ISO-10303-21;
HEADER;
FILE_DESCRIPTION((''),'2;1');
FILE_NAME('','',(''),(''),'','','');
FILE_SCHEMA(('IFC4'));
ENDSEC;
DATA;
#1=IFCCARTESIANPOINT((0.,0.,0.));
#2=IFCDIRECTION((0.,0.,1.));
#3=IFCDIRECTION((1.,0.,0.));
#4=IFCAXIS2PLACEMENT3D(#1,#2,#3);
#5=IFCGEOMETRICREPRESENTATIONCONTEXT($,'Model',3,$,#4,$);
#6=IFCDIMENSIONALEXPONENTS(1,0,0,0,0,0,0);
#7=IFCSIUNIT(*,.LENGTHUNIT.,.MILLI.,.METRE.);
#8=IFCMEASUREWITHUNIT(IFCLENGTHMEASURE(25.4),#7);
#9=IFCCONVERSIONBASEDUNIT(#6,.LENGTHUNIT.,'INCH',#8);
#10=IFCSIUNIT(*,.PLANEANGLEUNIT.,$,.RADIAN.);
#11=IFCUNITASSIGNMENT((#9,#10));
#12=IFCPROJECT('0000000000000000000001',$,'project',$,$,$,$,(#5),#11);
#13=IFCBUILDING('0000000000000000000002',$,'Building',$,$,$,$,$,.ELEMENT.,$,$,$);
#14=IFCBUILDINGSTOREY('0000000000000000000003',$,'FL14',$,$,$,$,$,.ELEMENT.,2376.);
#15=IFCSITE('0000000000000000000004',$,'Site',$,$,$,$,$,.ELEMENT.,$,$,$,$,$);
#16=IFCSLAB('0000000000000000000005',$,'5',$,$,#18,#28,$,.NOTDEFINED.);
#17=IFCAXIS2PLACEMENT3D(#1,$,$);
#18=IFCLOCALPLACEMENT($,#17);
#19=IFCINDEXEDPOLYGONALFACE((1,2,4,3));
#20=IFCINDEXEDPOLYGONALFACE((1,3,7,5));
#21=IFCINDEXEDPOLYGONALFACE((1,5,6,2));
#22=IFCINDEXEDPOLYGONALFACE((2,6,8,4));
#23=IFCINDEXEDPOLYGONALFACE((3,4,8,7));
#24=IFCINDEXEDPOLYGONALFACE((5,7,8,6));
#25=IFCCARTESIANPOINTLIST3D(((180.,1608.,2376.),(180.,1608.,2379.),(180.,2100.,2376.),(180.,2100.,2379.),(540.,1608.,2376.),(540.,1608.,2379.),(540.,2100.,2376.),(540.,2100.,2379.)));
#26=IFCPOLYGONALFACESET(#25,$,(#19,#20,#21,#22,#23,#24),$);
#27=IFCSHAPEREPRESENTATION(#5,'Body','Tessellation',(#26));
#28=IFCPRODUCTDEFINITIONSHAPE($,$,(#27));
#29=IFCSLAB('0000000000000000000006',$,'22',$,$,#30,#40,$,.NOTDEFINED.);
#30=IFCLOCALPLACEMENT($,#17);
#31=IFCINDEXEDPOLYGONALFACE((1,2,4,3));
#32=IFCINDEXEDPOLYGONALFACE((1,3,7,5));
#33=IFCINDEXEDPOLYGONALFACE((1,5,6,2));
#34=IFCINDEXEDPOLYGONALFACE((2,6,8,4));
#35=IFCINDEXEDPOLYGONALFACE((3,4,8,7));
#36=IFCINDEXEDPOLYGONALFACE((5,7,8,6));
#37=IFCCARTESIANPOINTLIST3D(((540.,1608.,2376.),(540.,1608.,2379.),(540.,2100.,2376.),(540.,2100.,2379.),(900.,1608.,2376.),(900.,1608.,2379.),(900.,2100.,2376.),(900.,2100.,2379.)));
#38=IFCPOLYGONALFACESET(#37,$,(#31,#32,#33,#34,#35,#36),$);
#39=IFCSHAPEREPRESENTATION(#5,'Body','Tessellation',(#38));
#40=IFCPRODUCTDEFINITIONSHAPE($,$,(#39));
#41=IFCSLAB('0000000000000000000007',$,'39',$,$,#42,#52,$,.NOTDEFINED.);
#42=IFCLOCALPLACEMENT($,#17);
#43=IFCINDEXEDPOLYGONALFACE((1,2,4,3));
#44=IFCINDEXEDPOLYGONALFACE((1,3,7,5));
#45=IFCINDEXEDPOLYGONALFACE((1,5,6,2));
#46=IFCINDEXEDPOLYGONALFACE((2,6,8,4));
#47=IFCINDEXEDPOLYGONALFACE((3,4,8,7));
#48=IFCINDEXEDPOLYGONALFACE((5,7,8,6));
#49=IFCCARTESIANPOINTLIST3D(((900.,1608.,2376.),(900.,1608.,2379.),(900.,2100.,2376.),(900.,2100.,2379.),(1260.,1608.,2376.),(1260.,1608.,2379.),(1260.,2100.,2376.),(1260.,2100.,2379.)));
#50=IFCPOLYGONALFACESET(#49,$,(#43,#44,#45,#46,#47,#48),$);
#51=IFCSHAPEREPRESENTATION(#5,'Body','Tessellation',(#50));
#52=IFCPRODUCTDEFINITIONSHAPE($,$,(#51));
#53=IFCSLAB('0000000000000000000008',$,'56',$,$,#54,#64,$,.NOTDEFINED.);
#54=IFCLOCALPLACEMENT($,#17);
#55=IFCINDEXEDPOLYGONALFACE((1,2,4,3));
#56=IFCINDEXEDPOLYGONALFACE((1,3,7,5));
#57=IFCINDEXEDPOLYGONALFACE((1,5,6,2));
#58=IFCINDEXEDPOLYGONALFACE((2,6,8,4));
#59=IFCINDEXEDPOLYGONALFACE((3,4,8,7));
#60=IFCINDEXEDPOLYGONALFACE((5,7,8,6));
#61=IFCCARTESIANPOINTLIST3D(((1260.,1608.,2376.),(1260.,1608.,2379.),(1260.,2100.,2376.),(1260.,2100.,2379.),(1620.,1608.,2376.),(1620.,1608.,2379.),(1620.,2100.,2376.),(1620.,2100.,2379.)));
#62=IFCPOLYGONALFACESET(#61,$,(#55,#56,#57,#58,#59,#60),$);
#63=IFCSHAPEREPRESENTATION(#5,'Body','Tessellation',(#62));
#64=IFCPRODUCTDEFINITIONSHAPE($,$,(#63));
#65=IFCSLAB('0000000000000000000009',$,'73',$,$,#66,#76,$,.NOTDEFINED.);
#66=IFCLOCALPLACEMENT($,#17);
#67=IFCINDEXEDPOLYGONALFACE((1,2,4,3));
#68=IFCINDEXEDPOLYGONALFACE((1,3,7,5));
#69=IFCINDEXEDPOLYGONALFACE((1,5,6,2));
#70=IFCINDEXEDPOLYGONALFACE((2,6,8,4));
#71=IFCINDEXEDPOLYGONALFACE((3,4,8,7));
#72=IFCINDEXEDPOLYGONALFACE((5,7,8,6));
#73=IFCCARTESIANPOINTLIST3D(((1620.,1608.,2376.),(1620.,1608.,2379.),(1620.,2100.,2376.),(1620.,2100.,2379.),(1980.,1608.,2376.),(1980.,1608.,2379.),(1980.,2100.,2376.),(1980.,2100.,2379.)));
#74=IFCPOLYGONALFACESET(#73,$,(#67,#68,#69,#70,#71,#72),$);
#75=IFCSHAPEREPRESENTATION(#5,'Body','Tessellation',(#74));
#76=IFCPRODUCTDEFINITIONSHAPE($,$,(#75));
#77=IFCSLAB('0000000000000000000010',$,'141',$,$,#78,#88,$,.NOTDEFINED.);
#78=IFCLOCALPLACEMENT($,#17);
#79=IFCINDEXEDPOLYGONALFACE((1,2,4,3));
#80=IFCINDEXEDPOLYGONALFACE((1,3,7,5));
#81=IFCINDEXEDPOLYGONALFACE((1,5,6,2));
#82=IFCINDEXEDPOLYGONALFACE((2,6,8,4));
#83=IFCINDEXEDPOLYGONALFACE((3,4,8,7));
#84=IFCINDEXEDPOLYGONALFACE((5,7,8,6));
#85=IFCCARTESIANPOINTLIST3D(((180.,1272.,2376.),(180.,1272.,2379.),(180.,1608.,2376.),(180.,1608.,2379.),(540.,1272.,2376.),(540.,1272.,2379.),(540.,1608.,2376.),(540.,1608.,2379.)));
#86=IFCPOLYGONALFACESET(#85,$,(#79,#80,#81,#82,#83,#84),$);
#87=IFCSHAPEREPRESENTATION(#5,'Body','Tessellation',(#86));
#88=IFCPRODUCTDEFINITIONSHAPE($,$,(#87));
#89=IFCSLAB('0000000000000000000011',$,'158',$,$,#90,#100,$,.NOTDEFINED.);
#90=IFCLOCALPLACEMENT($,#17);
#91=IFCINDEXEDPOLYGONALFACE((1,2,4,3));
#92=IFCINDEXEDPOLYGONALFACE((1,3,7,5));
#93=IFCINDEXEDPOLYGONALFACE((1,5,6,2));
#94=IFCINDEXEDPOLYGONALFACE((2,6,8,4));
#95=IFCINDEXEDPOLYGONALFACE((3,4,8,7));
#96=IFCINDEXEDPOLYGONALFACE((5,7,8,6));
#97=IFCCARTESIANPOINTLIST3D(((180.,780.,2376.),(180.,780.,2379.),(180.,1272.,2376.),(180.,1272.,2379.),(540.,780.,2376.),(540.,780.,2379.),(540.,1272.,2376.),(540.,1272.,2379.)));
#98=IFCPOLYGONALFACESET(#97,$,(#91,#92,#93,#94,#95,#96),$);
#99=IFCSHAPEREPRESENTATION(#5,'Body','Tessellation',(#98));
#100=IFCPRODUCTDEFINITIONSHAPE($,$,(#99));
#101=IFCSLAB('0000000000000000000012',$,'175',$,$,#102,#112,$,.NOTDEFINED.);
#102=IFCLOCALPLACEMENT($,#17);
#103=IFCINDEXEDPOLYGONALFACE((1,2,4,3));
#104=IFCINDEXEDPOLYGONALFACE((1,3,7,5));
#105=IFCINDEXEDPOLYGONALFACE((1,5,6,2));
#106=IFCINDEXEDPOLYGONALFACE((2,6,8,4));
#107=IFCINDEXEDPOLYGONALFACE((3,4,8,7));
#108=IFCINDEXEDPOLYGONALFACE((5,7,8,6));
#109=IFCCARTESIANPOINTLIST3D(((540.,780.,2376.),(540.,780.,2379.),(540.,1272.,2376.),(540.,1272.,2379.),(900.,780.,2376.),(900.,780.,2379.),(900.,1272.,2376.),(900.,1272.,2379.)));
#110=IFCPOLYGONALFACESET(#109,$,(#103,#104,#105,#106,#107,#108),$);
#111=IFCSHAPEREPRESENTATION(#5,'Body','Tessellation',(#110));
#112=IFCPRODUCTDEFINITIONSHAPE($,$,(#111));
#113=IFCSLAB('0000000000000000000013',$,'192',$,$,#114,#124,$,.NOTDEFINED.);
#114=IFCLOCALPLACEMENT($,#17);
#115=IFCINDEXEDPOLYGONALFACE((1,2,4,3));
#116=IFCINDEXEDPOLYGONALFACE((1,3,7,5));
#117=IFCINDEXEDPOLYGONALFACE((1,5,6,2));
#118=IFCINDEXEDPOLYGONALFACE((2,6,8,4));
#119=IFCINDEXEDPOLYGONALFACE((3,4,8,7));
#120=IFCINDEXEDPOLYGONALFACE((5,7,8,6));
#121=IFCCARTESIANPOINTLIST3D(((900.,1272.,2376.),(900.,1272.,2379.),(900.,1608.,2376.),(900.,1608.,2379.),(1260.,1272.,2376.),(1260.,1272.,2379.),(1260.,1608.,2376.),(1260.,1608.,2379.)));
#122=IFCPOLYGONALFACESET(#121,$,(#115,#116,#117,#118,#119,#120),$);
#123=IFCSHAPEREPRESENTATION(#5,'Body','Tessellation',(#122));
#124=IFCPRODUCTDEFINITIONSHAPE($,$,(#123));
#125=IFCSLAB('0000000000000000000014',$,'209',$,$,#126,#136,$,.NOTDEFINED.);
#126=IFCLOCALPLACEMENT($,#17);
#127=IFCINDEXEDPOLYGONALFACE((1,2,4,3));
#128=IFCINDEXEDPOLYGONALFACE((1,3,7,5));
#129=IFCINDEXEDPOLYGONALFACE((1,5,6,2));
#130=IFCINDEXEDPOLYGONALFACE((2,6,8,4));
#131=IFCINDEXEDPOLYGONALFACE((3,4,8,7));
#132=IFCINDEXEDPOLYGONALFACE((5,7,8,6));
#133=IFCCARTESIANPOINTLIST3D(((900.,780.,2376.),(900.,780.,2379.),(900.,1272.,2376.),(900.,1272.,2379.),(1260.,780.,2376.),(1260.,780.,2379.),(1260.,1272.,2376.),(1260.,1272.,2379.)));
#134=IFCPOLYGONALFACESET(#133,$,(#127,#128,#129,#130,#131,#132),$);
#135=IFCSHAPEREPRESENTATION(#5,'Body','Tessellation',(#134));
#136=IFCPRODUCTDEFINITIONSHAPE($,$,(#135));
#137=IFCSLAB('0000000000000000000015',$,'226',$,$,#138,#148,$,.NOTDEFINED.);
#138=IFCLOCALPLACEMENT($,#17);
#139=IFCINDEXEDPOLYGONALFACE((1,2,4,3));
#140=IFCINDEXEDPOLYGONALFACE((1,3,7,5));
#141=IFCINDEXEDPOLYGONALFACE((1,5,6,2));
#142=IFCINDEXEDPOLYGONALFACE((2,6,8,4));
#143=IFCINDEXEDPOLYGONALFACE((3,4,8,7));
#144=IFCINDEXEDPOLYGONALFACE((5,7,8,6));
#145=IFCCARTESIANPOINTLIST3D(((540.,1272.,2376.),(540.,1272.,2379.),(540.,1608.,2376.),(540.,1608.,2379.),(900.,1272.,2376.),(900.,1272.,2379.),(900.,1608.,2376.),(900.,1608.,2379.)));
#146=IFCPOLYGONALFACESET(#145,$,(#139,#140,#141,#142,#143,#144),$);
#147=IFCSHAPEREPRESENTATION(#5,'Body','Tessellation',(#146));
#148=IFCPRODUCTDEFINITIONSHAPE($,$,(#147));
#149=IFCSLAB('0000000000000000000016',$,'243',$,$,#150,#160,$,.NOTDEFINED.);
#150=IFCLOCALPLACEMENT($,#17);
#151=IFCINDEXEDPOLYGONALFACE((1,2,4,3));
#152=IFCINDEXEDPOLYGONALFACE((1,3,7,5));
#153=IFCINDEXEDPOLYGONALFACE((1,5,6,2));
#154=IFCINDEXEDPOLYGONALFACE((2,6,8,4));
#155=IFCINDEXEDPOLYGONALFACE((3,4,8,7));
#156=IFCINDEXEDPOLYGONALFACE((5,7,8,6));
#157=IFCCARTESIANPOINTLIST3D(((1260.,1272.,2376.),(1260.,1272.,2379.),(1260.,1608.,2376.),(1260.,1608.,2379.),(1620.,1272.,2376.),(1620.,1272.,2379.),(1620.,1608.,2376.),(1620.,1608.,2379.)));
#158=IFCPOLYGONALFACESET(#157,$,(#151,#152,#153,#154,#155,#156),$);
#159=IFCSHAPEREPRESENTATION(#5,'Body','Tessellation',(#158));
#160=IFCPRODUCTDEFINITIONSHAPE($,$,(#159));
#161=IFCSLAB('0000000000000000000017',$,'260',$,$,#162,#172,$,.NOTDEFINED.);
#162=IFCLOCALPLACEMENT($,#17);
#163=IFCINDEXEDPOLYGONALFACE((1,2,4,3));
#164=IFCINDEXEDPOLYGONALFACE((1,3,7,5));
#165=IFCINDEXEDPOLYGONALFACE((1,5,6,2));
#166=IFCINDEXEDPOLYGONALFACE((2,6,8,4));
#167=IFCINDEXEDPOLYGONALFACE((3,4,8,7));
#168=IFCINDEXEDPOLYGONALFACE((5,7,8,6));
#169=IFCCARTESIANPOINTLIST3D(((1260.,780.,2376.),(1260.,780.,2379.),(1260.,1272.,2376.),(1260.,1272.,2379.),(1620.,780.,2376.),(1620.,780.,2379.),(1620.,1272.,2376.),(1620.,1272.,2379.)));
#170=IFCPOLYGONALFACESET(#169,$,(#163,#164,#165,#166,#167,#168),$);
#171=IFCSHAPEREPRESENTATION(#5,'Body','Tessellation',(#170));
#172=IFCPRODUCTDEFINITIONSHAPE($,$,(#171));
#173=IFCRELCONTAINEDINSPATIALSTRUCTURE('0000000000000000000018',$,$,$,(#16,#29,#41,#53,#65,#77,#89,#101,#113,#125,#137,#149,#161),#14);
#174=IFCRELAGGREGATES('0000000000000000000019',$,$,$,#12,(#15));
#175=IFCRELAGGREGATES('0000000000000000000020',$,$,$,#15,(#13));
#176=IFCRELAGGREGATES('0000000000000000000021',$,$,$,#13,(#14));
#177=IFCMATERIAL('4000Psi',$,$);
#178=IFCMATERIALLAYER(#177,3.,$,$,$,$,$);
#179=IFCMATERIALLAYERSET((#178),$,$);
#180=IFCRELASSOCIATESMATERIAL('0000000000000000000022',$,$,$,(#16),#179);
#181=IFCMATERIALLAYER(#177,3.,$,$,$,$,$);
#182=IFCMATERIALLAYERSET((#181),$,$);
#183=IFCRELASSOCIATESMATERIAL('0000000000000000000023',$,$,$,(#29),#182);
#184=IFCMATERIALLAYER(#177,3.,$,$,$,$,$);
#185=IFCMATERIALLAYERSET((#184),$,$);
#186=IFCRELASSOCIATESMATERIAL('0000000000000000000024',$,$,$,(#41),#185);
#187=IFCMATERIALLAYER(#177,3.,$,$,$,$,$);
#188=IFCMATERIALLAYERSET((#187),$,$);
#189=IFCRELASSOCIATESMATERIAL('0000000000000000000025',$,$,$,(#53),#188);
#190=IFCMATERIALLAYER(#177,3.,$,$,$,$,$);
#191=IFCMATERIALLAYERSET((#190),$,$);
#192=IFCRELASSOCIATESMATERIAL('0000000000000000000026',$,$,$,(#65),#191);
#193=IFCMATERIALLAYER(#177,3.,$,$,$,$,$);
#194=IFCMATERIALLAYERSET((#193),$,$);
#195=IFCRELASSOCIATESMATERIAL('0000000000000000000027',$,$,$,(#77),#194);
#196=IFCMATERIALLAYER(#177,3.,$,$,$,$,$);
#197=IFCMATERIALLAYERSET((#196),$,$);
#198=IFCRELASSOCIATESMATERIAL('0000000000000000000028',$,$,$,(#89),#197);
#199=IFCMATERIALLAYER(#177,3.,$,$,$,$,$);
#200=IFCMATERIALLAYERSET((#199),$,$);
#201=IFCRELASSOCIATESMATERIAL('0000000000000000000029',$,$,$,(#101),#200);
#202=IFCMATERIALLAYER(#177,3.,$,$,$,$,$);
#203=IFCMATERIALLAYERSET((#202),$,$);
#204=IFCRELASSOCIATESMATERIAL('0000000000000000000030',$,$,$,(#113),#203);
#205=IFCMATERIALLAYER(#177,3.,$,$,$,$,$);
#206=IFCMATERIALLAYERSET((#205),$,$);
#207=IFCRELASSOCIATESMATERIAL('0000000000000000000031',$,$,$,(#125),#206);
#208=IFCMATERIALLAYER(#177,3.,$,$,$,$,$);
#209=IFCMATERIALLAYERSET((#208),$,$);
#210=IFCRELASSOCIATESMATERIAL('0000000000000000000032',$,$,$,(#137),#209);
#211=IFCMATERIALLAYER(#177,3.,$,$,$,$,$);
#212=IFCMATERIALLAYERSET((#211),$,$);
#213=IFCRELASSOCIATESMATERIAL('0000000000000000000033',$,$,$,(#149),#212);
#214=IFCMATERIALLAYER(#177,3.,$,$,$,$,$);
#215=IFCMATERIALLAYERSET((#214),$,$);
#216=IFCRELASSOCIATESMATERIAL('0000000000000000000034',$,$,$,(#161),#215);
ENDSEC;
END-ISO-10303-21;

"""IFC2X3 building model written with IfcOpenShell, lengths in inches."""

from ifc_helpers import new_model, entity, si_unit, converted_unit, frame, origin_with_axes, place, context, project, spatial, polyline, outline, extrude, material, layer, layer_set, layer_usage, element, save


model = new_model("IFC2X3")

# Units and contexts
model_context = context("Model", 3, world=origin_with_axes())
ifc_project = project(units=[converted_unit("LENGTHUNIT", "INCH", entity("IfcLengthMeasure", 25.4), si_unit("LENGTHUNIT", "METRE", prefix="MILLI"), dimensions=[1, 0, 0, 0, 0, 0, 0]), si_unit("PLANEANGLEUNIT", "RADIAN")], contexts=[model_context])

# Site, building, storey
site = spatial("IfcSite", under=ifc_project, Name="Site", CompositionType="ELEMENT")
building = spatial("IfcBuilding", under=site, Name="Building", CompositionType="ELEMENT")
storey = spatial("IfcBuildingStorey", under=building, Name="FL14", CompositionType="ELEMENT", Elevation=2376.0)

# Slabs
ifc_material_1 = material(Name="4000Psi")
ifc_layer_1 = layer(ifc_material_1, 3.0)
ifc_layer_set_1 = layer_set([ifc_layer_1])
ifc_layer_usage_1 = layer_usage(ifc_layer_set_1, "AXIS2", "POSITIVE", -3.0)
slab_1_placement = place(None, frame((180.0, 1608.0, 2376.0), z_axis=(0.0, 0.0, 1.0), x_axis=(1.0, 0.0, 0.0)))
element("IfcSlab", 1, at=slab_1_placement, inside=storey, material=ifc_layer_usage_1, Name="5", PredefinedType="NOTDEFINED", context=model_context, shape_type="SweptSolid", body=[
    extrude(outline(polyline([(0.0, 0.0), (360.0, 0.0), (360.0, 492.0), (0.0, 492.0), (0.0, 0.0)])), origin_with_axes(), (0.0, 0.0, 1.0), 3.0),
])
ifc_layer_2 = layer(ifc_material_1, 3.0)
ifc_layer_set_2 = layer_set([ifc_layer_2])
ifc_layer_usage_2 = layer_usage(ifc_layer_set_2, "AXIS2", "POSITIVE", -3.0)
slab_2_placement = place(None, frame((540.0, 1608.0, 2376.0), z_axis=(0.0, 0.0, 1.0), x_axis=(1.0, 0.0, 0.0)))
element("IfcSlab", 2, at=slab_2_placement, inside=storey, material=ifc_layer_usage_2, Name="22", PredefinedType="NOTDEFINED", context=model_context, shape_type="SweptSolid", body=[
    extrude(outline(polyline([(0.0, 0.0), (360.0, 0.0), (360.0, 492.0), (0.0, 492.0), (0.0, 0.0)])), origin_with_axes(), (0.0, 0.0, 1.0), 3.0),
])
ifc_layer_3 = layer(ifc_material_1, 3.0)
ifc_layer_set_3 = layer_set([ifc_layer_3])
ifc_layer_usage_3 = layer_usage(ifc_layer_set_3, "AXIS2", "POSITIVE", -3.0)
slab_3_placement = place(None, frame((900.0, 1608.0, 2376.0), z_axis=(0.0, 0.0, 1.0), x_axis=(1.0, 0.0, 0.0)))
element("IfcSlab", 3, at=slab_3_placement, inside=storey, material=ifc_layer_usage_3, Name="39", PredefinedType="NOTDEFINED", context=model_context, shape_type="SweptSolid", body=[
    extrude(outline(polyline([(0.0, 0.0), (360.0, 0.0), (360.0, 492.0), (0.0, 492.0), (0.0, 0.0)])), origin_with_axes(), (0.0, 0.0, 1.0), 3.0),
])
ifc_layer_4 = layer(ifc_material_1, 3.0)
ifc_layer_set_4 = layer_set([ifc_layer_4])
ifc_layer_usage_4 = layer_usage(ifc_layer_set_4, "AXIS2", "POSITIVE", -3.0)
slab_4_placement = place(None, frame((1260.0, 1608.0, 2376.0), z_axis=(0.0, 0.0, 1.0), x_axis=(1.0, 0.0, 0.0)))
element("IfcSlab", 4, at=slab_4_placement, inside=storey, material=ifc_layer_usage_4, Name="56", PredefinedType="NOTDEFINED", context=model_context, shape_type="SweptSolid", body=[
    extrude(outline(polyline([(0.0, 0.0), (360.0, 0.0), (360.0, 492.0), (0.0, 492.0), (0.0, 0.0)])), origin_with_axes(), (0.0, 0.0, 1.0), 3.0),
])
ifc_layer_5 = layer(ifc_material_1, 3.0)
ifc_layer_set_5 = layer_set([ifc_layer_5])
ifc_layer_usage_5 = layer_usage(ifc_layer_set_5, "AXIS2", "POSITIVE", -3.0)
slab_5_placement = place(None, frame((1620.0, 1608.0, 2376.0), z_axis=(0.0, 0.0, 1.0), x_axis=(1.0, 0.0, 0.0)))
element("IfcSlab", 5, at=slab_5_placement, inside=storey, material=ifc_layer_usage_5, Name="73", PredefinedType="NOTDEFINED", context=model_context, shape_type="SweptSolid", body=[
    extrude(outline(polyline([(0.0, 0.0), (360.0, 0.0), (360.0, 492.0), (0.0, 492.0), (0.0, 0.0)])), origin_with_axes(), (0.0, 0.0, 1.0), 3.0),
])
ifc_layer_6 = layer(ifc_material_1, 3.0)
ifc_layer_set_6 = layer_set([ifc_layer_6])
ifc_layer_usage_6 = layer_usage(ifc_layer_set_6, "AXIS2", "POSITIVE", -3.0)
slab_6_placement = place(None, frame((180.0, 1272.0, 2376.0), z_axis=(0.0, 0.0, 1.0), x_axis=(1.0, 0.0, 0.0)))
element("IfcSlab", 6, at=slab_6_placement, inside=storey, material=ifc_layer_usage_6, Name="141", PredefinedType="NOTDEFINED", context=model_context, shape_type="SweptSolid", body=[
    extrude(outline(polyline([(0.0, 0.0), (360.0, 0.0), (360.0, 336.0), (0.0, 336.0), (0.0, 0.0)])), origin_with_axes(), (0.0, 0.0, 1.0), 3.0),
])
ifc_layer_7 = layer(ifc_material_1, 3.0)
ifc_layer_set_7 = layer_set([ifc_layer_7])
ifc_layer_usage_7 = layer_usage(ifc_layer_set_7, "AXIS2", "POSITIVE", -3.0)
slab_7_placement = place(None, frame((180.0, 780.0, 2376.0), z_axis=(0.0, 0.0, 1.0), x_axis=(1.0, 0.0, 0.0)))
element("IfcSlab", 7, at=slab_7_placement, inside=storey, material=ifc_layer_usage_7, Name="158", PredefinedType="NOTDEFINED", context=model_context, shape_type="SweptSolid", body=[
    extrude(outline(polyline([(0.0, 0.0), (360.0, 0.0), (360.0, 492.0), (0.0, 492.0), (0.0, 0.0)])), origin_with_axes(), (0.0, 0.0, 1.0), 3.0),
])
ifc_layer_8 = layer(ifc_material_1, 3.0)
ifc_layer_set_8 = layer_set([ifc_layer_8])
ifc_layer_usage_8 = layer_usage(ifc_layer_set_8, "AXIS2", "POSITIVE", -3.0)
slab_8_placement = place(None, frame((540.0, 780.0, 2376.0), z_axis=(0.0, 0.0, 1.0), x_axis=(1.0, 0.0, 0.0)))
element("IfcSlab", 8, at=slab_8_placement, inside=storey, material=ifc_layer_usage_8, Name="175", PredefinedType="NOTDEFINED", context=model_context, shape_type="SweptSolid", body=[
    extrude(outline(polyline([(0.0, 0.0), (360.0, 0.0), (360.0, 492.0), (0.0, 492.0), (0.0, 0.0)])), origin_with_axes(), (0.0, 0.0, 1.0), 3.0),
])
ifc_layer_9 = layer(ifc_material_1, 3.0)
ifc_layer_set_9 = layer_set([ifc_layer_9])
ifc_layer_usage_9 = layer_usage(ifc_layer_set_9, "AXIS2", "POSITIVE", -3.0)
slab_9_placement = place(None, frame((900.0, 1272.0, 2376.0), z_axis=(0.0, 0.0, 1.0), x_axis=(1.0, 0.0, 0.0)))
element("IfcSlab", 9, at=slab_9_placement, inside=storey, material=ifc_layer_usage_9, Name="192", PredefinedType="NOTDEFINED", context=model_context, shape_type="SweptSolid", body=[
    extrude(outline(polyline([(0.0, 0.0), (360.0, 0.0), (360.0, 336.0), (0.0, 336.0), (0.0, 0.0)])), origin_with_axes(), (0.0, 0.0, 1.0), 3.0),
])
ifc_layer_10 = layer(ifc_material_1, 3.0)
ifc_layer_set_10 = layer_set([ifc_layer_10])
ifc_layer_usage_10 = layer_usage(ifc_layer_set_10, "AXIS2", "POSITIVE", -3.0)
slab_10_placement = place(None, frame((900.0, 780.0, 2376.0), z_axis=(0.0, 0.0, 1.0), x_axis=(1.0, 0.0, 0.0)))
element("IfcSlab", 10, at=slab_10_placement, inside=storey, material=ifc_layer_usage_10, Name="209", PredefinedType="NOTDEFINED", context=model_context, shape_type="SweptSolid", body=[
    extrude(outline(polyline([(0.0, 0.0), (360.0, 0.0), (360.0, 492.0), (0.0, 492.0), (0.0, 0.0)])), origin_with_axes(), (0.0, 0.0, 1.0), 3.0),
])
ifc_layer_11 = layer(ifc_material_1, 3.0)
ifc_layer_set_11 = layer_set([ifc_layer_11])
ifc_layer_usage_11 = layer_usage(ifc_layer_set_11, "AXIS2", "POSITIVE", -3.0)
slab_11_placement = place(None, frame((540.0, 1272.0, 2376.0), z_axis=(0.0, 0.0, 1.0), x_axis=(1.0, 0.0, 0.0)))
element("IfcSlab", 11, at=slab_11_placement, inside=storey, material=ifc_layer_usage_11, Name="226", PredefinedType="NOTDEFINED", context=model_context, shape_type="SweptSolid", body=[
    extrude(outline(polyline([(0.0, 0.0), (360.0, 0.0), (360.0, 336.0), (0.0, 336.0), (0.0, 0.0)])), origin_with_axes(), (0.0, 0.0, 1.0), 3.0),
])
ifc_layer_12 = layer(ifc_material_1, 3.0)
ifc_layer_set_12 = layer_set([ifc_layer_12])
ifc_layer_usage_12 = layer_usage(ifc_layer_set_12, "AXIS2", "POSITIVE", -3.0)
slab_12_placement = place(None, frame((1260.0, 1272.0, 2376.0), z_axis=(0.0, 0.0, 1.0), x_axis=(1.0, 0.0, 0.0)))
element("IfcSlab", 12, at=slab_12_placement, inside=storey, material=ifc_layer_usage_12, Name="243", PredefinedType="NOTDEFINED", context=model_context, shape_type="SweptSolid", body=[
    extrude(outline(polyline([(0.0, 0.0), (360.0, 0.0), (360.0, 336.0), (0.0, 336.0), (0.0, 0.0)])), origin_with_axes(), (0.0, 0.0, 1.0), 3.0),
])
ifc_layer_13 = layer(ifc_material_1, 3.0)
ifc_layer_set_13 = layer_set([ifc_layer_13])
ifc_layer_usage_13 = layer_usage(ifc_layer_set_13, "AXIS2", "POSITIVE", -3.0)
slab_13_placement = place(None, frame((1260.0, 780.0, 2376.0), z_axis=(0.0, 0.0, 1.0), x_axis=(1.0, 0.0, 0.0)))
element("IfcSlab", 13, at=slab_13_placement, inside=storey, material=ifc_layer_usage_13, Name="260", PredefinedType="NOTDEFINED", context=model_context, shape_type="SweptSolid", body=[
    extrude(outline(polyline([(0.0, 0.0), (360.0, 0.0), (360.0, 492.0), (0.0, 492.0), (0.0, 0.0)])), origin_with_axes(), (0.0, 0.0, 1.0), 3.0),
])

save(model, "model.ifc")
